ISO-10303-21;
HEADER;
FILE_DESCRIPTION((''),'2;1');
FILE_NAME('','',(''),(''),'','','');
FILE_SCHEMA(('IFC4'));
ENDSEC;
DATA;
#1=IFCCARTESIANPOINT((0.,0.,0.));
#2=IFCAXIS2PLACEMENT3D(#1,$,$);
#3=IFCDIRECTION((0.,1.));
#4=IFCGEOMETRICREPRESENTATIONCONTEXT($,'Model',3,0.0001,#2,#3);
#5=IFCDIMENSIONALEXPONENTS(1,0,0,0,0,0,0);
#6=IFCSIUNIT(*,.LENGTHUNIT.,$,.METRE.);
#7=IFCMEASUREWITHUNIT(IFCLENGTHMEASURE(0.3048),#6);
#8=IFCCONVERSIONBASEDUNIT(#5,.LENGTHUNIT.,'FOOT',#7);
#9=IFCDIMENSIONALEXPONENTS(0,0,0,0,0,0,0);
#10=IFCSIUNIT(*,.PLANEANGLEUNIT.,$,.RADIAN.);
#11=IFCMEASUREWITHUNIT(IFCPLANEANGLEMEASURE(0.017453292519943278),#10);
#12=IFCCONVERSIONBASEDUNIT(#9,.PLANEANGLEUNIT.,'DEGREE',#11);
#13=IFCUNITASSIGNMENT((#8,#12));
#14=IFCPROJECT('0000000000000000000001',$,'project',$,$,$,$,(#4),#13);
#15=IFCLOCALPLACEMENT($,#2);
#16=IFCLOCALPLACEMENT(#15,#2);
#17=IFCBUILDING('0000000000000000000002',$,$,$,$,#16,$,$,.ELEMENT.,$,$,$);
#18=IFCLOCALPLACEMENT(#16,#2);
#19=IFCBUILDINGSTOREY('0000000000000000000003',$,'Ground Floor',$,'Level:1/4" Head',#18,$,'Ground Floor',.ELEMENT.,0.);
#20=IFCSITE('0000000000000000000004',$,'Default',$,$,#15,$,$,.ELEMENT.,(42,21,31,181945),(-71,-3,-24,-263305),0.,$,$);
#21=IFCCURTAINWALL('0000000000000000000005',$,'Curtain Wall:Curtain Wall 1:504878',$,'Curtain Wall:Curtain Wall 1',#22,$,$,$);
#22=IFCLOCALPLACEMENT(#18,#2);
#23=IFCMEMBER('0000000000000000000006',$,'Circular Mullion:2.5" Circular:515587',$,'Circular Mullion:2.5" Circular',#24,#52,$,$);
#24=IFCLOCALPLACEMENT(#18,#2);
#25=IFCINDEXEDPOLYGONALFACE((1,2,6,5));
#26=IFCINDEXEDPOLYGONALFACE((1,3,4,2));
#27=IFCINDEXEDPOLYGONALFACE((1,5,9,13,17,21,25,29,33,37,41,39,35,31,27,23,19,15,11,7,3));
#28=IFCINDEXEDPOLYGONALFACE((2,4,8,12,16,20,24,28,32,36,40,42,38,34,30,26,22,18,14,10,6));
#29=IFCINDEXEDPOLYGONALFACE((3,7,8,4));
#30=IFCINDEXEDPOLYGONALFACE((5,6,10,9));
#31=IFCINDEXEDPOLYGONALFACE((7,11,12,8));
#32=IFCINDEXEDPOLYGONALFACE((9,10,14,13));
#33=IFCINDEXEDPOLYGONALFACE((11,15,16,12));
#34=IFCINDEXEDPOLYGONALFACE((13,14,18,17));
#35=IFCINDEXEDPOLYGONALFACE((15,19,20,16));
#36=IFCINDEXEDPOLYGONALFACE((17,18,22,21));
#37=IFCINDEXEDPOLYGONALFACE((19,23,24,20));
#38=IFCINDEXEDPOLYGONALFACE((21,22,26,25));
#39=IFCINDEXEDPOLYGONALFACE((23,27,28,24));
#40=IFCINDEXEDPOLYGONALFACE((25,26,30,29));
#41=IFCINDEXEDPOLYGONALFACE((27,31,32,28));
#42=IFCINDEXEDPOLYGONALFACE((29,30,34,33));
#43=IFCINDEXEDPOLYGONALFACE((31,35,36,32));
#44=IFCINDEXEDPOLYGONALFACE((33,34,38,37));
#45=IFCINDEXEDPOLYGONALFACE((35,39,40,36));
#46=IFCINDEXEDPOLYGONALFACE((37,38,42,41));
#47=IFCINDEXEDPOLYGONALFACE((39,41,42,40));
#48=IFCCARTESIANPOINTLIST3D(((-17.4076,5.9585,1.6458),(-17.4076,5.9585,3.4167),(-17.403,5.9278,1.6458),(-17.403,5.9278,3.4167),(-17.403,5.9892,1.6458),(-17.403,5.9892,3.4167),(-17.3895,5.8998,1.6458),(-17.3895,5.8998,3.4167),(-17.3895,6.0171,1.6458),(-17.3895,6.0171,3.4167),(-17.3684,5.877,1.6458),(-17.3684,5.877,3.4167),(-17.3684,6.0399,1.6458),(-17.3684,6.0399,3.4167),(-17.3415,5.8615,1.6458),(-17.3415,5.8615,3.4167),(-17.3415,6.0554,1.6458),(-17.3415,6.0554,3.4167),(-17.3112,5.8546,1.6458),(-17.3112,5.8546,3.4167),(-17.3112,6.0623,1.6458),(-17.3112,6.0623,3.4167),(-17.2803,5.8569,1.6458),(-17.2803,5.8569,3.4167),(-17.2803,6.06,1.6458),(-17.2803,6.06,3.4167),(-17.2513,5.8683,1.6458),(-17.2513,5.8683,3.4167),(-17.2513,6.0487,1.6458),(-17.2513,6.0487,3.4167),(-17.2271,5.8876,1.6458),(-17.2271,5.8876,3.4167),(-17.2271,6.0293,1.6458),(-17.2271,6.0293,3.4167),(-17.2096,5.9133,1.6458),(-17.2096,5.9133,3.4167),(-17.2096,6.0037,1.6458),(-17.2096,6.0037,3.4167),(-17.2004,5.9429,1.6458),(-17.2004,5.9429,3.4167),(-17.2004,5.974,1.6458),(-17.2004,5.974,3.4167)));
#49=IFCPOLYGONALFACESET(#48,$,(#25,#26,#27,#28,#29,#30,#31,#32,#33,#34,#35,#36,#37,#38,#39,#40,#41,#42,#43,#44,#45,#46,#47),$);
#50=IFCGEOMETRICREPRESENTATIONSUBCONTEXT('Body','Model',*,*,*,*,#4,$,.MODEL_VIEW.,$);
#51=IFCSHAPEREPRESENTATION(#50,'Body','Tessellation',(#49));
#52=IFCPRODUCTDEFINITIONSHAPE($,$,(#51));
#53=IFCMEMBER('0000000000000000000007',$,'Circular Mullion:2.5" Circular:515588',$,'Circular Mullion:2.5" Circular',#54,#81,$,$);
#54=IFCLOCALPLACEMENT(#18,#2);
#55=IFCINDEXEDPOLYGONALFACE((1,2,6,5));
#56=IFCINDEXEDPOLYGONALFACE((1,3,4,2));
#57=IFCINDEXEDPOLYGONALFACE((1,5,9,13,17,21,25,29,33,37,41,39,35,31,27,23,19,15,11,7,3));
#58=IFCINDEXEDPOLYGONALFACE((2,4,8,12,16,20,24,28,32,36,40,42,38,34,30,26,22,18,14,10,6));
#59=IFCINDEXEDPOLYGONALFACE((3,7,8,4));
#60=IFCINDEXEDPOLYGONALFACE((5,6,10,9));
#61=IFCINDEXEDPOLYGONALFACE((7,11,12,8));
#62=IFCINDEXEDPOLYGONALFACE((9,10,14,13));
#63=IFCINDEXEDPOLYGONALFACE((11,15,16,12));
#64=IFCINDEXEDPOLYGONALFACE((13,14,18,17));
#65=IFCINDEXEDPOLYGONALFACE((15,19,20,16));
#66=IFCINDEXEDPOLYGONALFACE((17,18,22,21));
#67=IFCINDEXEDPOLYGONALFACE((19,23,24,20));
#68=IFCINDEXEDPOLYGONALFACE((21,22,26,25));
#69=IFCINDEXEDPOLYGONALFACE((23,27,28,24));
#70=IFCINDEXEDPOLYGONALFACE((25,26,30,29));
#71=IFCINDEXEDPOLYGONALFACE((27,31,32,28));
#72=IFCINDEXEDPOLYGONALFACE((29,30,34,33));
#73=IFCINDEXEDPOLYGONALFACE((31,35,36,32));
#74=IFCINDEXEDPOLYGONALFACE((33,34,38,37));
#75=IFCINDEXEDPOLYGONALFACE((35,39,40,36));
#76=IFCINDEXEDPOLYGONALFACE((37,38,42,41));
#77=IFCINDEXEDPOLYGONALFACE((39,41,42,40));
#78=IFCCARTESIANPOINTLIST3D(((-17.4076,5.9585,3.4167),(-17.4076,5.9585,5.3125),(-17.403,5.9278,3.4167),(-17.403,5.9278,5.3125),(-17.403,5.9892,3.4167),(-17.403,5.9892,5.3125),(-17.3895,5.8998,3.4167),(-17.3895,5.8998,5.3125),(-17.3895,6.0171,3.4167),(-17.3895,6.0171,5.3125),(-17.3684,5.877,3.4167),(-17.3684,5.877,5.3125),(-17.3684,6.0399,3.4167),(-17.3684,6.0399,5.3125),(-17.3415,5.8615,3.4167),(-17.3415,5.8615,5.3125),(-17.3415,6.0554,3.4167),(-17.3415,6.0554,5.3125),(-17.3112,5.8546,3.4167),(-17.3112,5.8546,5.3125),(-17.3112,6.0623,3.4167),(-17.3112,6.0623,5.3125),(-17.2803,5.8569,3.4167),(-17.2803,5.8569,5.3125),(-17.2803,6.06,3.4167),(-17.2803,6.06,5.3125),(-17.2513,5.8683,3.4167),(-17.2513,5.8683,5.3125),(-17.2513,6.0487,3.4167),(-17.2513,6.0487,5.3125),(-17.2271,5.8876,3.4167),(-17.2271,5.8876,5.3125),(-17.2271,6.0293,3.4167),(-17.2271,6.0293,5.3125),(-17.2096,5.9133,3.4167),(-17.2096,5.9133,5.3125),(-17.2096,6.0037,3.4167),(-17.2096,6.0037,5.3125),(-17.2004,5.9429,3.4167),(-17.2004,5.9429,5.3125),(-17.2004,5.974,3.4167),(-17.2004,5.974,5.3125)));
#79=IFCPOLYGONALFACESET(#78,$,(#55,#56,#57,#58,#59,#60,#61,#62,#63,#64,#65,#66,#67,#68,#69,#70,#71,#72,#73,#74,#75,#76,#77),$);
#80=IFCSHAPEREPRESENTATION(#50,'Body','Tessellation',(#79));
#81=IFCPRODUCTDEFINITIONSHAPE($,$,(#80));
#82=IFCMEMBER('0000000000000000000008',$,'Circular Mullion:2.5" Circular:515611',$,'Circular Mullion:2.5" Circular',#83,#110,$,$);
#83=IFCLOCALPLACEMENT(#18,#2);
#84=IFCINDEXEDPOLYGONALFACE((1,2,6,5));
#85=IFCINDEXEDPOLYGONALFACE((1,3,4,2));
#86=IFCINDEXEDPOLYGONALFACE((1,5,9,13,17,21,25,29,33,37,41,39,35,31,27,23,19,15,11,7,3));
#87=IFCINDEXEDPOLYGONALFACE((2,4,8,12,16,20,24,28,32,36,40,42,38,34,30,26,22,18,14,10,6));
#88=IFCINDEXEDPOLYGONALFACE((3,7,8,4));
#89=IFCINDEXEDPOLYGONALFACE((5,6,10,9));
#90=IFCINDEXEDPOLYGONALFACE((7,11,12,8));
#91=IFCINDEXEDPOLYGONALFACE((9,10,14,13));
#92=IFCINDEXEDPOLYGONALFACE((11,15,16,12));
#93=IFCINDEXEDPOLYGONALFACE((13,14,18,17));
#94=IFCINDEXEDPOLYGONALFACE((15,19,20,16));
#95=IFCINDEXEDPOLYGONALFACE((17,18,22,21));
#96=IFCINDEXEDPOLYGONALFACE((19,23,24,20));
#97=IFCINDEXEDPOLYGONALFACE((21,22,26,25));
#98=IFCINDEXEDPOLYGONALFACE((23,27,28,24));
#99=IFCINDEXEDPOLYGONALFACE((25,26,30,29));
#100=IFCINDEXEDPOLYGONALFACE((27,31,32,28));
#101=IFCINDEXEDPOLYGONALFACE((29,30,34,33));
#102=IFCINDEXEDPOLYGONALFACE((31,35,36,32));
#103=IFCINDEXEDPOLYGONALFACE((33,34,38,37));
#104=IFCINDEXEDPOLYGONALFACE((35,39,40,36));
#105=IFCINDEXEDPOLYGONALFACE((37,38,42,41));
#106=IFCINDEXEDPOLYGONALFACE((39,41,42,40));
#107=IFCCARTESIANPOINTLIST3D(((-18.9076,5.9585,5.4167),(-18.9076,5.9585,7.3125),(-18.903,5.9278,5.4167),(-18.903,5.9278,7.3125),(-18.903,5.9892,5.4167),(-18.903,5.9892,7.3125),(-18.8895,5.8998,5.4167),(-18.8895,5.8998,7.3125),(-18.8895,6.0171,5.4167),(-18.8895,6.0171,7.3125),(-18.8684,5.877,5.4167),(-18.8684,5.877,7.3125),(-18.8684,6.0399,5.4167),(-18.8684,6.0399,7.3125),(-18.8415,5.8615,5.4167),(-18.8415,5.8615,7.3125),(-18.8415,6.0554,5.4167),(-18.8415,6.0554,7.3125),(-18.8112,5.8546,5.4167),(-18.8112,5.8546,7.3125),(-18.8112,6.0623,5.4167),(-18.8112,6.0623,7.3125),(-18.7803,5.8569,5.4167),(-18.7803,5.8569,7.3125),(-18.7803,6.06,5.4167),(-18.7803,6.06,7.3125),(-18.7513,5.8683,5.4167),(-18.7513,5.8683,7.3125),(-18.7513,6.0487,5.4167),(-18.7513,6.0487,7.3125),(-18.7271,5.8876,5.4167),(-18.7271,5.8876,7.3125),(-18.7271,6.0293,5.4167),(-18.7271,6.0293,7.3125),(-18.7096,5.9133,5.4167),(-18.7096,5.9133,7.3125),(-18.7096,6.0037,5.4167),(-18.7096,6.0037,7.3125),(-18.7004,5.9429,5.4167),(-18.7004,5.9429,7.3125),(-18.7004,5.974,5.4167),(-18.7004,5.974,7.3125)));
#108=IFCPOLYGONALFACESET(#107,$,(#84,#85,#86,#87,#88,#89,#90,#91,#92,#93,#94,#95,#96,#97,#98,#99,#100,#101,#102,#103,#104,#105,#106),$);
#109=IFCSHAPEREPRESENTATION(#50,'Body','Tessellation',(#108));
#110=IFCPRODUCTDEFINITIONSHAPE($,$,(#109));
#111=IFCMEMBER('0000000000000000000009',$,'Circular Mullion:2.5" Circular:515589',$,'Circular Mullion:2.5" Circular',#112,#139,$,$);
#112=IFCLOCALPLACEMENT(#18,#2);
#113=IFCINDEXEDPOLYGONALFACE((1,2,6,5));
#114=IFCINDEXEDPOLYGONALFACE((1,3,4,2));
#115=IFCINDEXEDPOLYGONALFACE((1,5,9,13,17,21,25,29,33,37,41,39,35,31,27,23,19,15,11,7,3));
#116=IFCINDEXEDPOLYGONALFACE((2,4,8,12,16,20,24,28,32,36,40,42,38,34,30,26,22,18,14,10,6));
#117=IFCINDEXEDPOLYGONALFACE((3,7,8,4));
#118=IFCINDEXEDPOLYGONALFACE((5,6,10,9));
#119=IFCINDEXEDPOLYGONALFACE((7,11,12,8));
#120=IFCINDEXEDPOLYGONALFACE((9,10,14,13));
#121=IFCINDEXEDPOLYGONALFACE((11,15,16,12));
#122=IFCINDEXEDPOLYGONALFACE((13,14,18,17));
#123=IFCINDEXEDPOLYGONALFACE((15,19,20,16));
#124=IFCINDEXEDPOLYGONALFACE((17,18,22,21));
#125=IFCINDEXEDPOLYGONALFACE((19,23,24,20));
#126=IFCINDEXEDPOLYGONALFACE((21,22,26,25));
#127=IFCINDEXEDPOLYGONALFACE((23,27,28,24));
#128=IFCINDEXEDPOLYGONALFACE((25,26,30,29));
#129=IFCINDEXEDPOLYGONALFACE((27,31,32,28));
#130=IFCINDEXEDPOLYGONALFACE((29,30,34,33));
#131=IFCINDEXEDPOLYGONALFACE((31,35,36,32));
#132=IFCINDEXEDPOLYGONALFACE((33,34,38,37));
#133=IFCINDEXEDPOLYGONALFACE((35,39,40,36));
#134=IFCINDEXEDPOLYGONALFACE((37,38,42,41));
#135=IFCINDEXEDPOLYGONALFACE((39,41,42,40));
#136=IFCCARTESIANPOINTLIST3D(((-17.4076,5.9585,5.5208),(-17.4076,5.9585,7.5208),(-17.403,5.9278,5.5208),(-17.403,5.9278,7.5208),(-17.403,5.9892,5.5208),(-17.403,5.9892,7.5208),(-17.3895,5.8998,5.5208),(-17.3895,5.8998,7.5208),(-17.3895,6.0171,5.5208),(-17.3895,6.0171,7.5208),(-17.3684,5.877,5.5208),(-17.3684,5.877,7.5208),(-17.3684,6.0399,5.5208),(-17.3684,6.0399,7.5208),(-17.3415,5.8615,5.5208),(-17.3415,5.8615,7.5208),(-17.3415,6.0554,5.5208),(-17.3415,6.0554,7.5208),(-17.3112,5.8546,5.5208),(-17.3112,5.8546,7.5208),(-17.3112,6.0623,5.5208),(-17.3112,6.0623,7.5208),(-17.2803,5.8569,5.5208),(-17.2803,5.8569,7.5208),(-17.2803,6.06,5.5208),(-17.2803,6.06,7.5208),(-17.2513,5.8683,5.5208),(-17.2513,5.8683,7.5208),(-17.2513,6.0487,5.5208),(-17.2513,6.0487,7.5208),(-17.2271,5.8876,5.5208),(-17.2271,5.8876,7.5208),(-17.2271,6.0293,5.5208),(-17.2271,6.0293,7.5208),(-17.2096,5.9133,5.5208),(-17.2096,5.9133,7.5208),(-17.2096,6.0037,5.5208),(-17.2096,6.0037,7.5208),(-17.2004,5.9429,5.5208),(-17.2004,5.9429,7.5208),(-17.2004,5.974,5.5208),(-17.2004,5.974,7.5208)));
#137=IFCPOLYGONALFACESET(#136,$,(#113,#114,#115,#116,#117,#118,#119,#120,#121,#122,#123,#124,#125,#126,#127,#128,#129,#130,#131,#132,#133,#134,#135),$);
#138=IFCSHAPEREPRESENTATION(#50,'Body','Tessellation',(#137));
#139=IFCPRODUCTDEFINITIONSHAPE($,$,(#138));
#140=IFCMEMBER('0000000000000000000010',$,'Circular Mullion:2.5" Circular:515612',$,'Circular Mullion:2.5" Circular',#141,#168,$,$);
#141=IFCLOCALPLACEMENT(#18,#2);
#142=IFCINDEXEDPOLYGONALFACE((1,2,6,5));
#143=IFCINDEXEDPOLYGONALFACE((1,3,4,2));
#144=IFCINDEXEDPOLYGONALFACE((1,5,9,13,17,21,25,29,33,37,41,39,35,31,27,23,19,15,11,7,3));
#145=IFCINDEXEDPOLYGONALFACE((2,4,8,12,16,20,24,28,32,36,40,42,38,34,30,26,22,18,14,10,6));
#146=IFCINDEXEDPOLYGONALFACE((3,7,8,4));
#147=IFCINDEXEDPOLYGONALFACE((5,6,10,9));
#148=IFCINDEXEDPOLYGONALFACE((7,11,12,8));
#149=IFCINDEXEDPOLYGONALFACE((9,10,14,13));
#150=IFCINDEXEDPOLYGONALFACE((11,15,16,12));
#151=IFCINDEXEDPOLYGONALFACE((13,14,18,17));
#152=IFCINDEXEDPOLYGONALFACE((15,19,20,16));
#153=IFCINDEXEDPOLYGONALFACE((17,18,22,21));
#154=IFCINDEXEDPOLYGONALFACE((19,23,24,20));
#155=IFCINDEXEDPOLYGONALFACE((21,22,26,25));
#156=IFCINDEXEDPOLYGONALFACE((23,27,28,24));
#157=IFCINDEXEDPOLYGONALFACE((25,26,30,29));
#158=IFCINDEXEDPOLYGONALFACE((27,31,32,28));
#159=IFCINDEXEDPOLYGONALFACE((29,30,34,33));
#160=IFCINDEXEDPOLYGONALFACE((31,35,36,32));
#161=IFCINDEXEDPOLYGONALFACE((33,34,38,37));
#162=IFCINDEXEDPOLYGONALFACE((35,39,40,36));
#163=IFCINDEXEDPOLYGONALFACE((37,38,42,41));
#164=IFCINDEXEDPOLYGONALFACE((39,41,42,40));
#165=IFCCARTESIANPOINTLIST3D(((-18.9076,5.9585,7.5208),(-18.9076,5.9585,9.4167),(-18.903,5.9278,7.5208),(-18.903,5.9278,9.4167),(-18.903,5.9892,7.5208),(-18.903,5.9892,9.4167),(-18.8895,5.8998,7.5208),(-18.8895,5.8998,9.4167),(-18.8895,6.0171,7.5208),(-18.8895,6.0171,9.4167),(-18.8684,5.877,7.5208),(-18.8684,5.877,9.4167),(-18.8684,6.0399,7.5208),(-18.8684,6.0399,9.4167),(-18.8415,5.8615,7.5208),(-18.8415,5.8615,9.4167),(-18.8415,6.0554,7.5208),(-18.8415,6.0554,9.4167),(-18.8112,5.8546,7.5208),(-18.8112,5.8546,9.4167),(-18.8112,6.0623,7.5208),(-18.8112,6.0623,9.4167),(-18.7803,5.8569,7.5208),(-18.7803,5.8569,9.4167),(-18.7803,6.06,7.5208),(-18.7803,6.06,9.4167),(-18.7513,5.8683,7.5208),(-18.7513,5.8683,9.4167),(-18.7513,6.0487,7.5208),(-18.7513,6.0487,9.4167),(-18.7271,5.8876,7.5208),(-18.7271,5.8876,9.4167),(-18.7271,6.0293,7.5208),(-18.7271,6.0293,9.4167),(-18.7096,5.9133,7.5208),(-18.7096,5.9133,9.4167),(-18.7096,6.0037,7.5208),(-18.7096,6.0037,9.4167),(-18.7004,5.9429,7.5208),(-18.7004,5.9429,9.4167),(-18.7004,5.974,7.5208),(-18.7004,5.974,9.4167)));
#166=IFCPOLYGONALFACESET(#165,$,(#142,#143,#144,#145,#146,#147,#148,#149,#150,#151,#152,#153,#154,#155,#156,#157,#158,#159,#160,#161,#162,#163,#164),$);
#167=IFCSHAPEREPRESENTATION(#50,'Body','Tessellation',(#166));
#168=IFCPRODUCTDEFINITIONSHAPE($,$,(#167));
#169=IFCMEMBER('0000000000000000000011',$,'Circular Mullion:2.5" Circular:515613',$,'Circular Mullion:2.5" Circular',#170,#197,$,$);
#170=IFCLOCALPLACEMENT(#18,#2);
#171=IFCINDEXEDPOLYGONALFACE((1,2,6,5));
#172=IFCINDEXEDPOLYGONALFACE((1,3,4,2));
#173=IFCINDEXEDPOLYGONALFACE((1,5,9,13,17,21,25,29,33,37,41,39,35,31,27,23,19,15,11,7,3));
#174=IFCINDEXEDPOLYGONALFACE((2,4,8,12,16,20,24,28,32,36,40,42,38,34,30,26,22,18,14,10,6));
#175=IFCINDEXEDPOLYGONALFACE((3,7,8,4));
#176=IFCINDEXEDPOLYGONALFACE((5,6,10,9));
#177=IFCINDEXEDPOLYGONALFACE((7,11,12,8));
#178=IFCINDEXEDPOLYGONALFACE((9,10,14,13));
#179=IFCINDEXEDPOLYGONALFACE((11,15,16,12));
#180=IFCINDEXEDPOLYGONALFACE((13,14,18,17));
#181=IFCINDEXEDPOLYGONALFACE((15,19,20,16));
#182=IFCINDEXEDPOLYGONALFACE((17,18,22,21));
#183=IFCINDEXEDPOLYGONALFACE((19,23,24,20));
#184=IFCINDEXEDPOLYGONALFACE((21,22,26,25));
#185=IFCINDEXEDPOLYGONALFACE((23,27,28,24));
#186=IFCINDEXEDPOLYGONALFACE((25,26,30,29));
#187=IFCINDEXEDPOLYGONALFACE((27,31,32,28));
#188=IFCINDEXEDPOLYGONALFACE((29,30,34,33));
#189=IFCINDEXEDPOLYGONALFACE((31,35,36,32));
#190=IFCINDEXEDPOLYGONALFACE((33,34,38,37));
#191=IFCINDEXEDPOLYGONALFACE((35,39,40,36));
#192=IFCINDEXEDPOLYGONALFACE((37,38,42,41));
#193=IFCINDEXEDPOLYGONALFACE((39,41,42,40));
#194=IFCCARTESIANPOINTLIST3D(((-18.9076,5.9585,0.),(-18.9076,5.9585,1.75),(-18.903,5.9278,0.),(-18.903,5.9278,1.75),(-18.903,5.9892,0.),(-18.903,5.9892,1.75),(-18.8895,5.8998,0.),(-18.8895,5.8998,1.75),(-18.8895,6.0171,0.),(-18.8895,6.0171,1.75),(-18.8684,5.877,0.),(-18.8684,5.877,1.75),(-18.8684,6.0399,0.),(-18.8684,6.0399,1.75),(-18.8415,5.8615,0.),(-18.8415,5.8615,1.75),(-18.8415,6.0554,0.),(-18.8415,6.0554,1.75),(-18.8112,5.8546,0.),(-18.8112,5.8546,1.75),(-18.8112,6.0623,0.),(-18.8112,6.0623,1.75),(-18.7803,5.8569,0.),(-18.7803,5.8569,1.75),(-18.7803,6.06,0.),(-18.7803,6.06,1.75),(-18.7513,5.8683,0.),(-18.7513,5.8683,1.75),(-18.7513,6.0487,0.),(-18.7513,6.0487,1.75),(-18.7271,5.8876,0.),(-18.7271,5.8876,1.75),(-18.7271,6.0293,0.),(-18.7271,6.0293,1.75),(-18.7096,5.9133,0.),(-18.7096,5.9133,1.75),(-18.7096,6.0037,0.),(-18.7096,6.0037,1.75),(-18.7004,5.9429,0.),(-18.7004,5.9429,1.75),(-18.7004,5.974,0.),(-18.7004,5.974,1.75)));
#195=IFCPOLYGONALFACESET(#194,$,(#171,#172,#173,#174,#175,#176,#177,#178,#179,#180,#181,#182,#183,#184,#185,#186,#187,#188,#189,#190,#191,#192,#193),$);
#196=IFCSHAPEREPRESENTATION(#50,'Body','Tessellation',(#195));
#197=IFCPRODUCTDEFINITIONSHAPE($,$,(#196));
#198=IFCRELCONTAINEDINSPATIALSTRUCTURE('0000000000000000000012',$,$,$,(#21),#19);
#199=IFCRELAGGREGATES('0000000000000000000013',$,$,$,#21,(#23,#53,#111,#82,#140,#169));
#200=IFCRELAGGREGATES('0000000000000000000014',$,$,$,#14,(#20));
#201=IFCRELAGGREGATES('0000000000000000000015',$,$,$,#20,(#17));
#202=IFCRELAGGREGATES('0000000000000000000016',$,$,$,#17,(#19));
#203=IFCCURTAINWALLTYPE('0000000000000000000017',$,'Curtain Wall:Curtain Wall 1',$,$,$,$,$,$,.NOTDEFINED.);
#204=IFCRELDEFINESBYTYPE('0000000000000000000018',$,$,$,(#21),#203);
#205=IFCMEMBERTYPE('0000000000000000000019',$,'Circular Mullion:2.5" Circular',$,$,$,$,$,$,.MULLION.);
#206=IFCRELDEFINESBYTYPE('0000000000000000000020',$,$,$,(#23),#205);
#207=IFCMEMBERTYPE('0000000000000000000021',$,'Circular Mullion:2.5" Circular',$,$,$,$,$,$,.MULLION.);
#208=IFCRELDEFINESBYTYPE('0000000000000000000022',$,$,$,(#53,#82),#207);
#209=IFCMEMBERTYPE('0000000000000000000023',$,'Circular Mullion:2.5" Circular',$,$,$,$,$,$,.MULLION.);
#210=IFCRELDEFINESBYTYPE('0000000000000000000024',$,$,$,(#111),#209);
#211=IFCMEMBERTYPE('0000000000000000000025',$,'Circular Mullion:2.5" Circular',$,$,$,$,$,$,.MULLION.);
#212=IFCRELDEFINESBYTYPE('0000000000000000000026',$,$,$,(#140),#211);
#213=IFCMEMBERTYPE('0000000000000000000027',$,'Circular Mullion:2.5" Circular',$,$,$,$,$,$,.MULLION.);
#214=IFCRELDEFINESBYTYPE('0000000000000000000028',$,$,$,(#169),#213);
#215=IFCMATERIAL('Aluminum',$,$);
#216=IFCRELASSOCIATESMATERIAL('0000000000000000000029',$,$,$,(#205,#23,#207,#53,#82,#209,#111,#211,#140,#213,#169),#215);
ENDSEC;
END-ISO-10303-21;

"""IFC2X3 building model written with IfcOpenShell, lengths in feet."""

from ifc_helpers import new_model, entity, si_unit, converted_unit, direction, frame, frame_2d, origin, place, context, subcontext, project, spatial, circle, extrude, source, transform, mapped, material, type_object, type_shapes, element, aggregate, save


model = new_model("IFC2X3")

# Units and contexts
model_context = context("Model", 3, precision=0.0001, world=origin(), true_north=direction((0.0, 1.0)))
body_context = subcontext(model_context, "Body", "Model", "MODEL_VIEW")
ifc_project = project(units=[converted_unit("LENGTHUNIT", "FOOT", entity("IfcLengthMeasure", 0.3048), si_unit("LENGTHUNIT", "METRE"), dimensions=[1, 0, 0, 0, 0, 0, 0]), converted_unit("PLANEANGLEUNIT", "DEGREE", entity("IfcPlaneAngleMeasure", 0.017453292519943278), si_unit("PLANEANGLEUNIT", "RADIAN"), dimensions=[0, 0, 0, 0, 0, 0, 0])], contexts=[model_context])

# Site, building, storey
site_placement = place(None, origin())
site = spatial("IfcSite", under=ifc_project, at=site_placement, Name="Default", CompositionType="ELEMENT", RefLatitude=(42, 21, 31, 181945), RefLongitude=(-71, -3, -24, -263305), RefElevation=0.0)
building_placement = place(site_placement, origin())
building = spatial("IfcBuilding", under=site, at=building_placement, CompositionType="ELEMENT")
storey_placement = place(building_placement, origin())
storey = spatial("IfcBuildingStorey", under=building, at=storey_placement, Name="Ground Floor", ObjectType="Level:1/4\" Head", LongName="Ground Floor", CompositionType="ELEMENT", Elevation=0.0)

# Curtain wall, members
curtain_wall_type = type_object("IfcCurtainWallType", Name="Curtain Wall:Curtain Wall 1", PredefinedType="NOTDEFINED")
curtain_wall_placement = place(storey_placement, origin())
curtain_wall = element("IfcCurtainWall", 1, at=curtain_wall_placement, inside=storey, type_object=curtain_wall_type, Name="Curtain Wall:Curtain Wall 1:504878", ObjectType="Curtain Wall:Curtain Wall 1")
ifc_material_1 = material(Name="Aluminum")
member_type_1 = type_object("IfcMemberType", Name="Circular Mullion:2.5\" Circular", PredefinedType="MULLION", material=ifc_material_1)
shared_shape_1 = source(origin(), body_context, "Body", "SweptSolid", [
    extrude(circle(Radius=0.1042, at=frame_2d((0.0, 0.0), x_axis=(1.0, 0.0))), frame((0.0, 0.0, -1.7708)), (0.0, 0.0, 1.0), 1.7708),
])
type_shapes(member_type_1, [shared_shape_1])
member_1_placement = place(curtain_wall_placement, frame((-17.3034, 5.9585, 1.6458), z_axis=(0.0, 0.0, -1.0), x_axis=(-1.0, 0.0, 0.0)))
member_1 = element("IfcMember", 2, at=member_1_placement, type_object=member_type_1, material=ifc_material_1, Name="Circular Mullion:2.5\" Circular:515587", ObjectType="Circular Mullion:2.5\" Circular", context=body_context, shape_type="MappedRepresentation", body=[
    mapped(shared_shape_1, transform((0.0, 0.0, 0.0), scale=1.0)),
])
member_type_2 = type_object("IfcMemberType", Name="Circular Mullion:2.5\" Circular", PredefinedType="MULLION", material=ifc_material_1)
shared_shape_2 = source(origin(), body_context, "Body", "SweptSolid", [
    extrude(circle(Radius=0.1042, at=frame_2d((0.0, 0.0), x_axis=(1.0, 0.0))), frame((0.0, 0.0, -1.8958)), (0.0, 0.0, 1.0), 1.8958),
])
type_shapes(member_type_2, [shared_shape_2])
member_2_placement = place(curtain_wall_placement, frame((-17.3034, 5.9585, 3.4167), z_axis=(0.0, 0.0, -1.0), x_axis=(-1.0, 0.0, 0.0)))
member_2 = element("IfcMember", 3, at=member_2_placement, type_object=member_type_2, material=ifc_material_1, Name="Circular Mullion:2.5\" Circular:515588", ObjectType="Circular Mullion:2.5\" Circular", context=body_context, shape_type="MappedRepresentation", body=[
    mapped(shared_shape_2, transform((0.0, 0.0, 0.0), scale=1.0)),
])
member_3_placement = place(curtain_wall_placement, frame((-18.8034, 5.9585, 5.4167), z_axis=(0.0, 0.0, -1.0), x_axis=(-1.0, 0.0, 0.0)))
member_3 = element("IfcMember", 4, at=member_3_placement, type_object=member_type_2, material=ifc_material_1, Name="Circular Mullion:2.5\" Circular:515611", ObjectType="Circular Mullion:2.5\" Circular", context=body_context, shape_type="MappedRepresentation", body=[
    mapped(shared_shape_2, transform((0.0, 0.0, 0.0), scale=1.0)),
])
member_type_3 = type_object("IfcMemberType", Name="Circular Mullion:2.5\" Circular", PredefinedType="MULLION", material=ifc_material_1)
shared_shape_3 = source(origin(), body_context, "Body", "SweptSolid", [
    extrude(circle(Radius=0.1042, at=frame_2d((0.0, 0.0), x_axis=(1.0, 0.0))), frame((0.0, 0.0, -2.0)), (0.0, 0.0, 1.0), 2.0),
])
type_shapes(member_type_3, [shared_shape_3])
member_4_placement = place(curtain_wall_placement, frame((-17.3034, 5.9585, 5.5208), z_axis=(0.0, 0.0, -1.0), x_axis=(-1.0, 0.0, 0.0)))
member_4 = element("IfcMember", 5, at=member_4_placement, type_object=member_type_3, material=ifc_material_1, Name="Circular Mullion:2.5\" Circular:515589", ObjectType="Circular Mullion:2.5\" Circular", context=body_context, shape_type="MappedRepresentation", body=[
    mapped(shared_shape_3, transform((0.0, 0.0, 0.0), scale=1.0)),
])
member_type_4 = type_object("IfcMemberType", Name="Circular Mullion:2.5\" Circular", PredefinedType="MULLION", material=ifc_material_1)
shared_shape_4 = source(origin(), body_context, "Body", "SweptSolid", [
    extrude(circle(Radius=0.1042, at=frame_2d((0.0, 0.0), x_axis=(1.0, 0.0))), frame((0.0, 0.0, -1.8958)), (0.0, 0.0, 1.0), 1.8958),
])
type_shapes(member_type_4, [shared_shape_4])
member_5_placement = place(curtain_wall_placement, frame((-18.8034, 5.9585, 7.5208), z_axis=(0.0, 0.0, -1.0), x_axis=(-1.0, 0.0, 0.0)))
member_5 = element("IfcMember", 6, at=member_5_placement, type_object=member_type_4, material=ifc_material_1, Name="Circular Mullion:2.5\" Circular:515612", ObjectType="Circular Mullion:2.5\" Circular", context=body_context, shape_type="MappedRepresentation", body=[
    mapped(shared_shape_4, transform((0.0, 0.0, 0.0), scale=1.0)),
])
member_type_5 = type_object("IfcMemberType", Name="Circular Mullion:2.5\" Circular", PredefinedType="MULLION", material=ifc_material_1)
shared_shape_5 = source(origin(), body_context, "Body", "SweptSolid", [
    extrude(circle(Radius=0.1042, at=frame_2d((0.0, 0.0), x_axis=(1.0, 0.0))), frame((0.0, 0.0, -1.75)), (0.0, 0.0, 1.0), 1.75),
])
type_shapes(member_type_5, [shared_shape_5])
member_6_placement = place(curtain_wall_placement, frame((-18.8034, 5.9585, 0.0), z_axis=(0.0, 0.0, -1.0), x_axis=(-1.0, 0.0, 0.0)))
member_6 = element("IfcMember", 7, at=member_6_placement, type_object=member_type_5, material=ifc_material_1, Name="Circular Mullion:2.5\" Circular:515613", ObjectType="Circular Mullion:2.5\" Circular", context=body_context, shape_type="MappedRepresentation", body=[
    mapped(shared_shape_5, transform((0.0, 0.0, 0.0), scale=1.0)),
])
aggregate(curtain_wall, [member_1, member_2, member_4, member_3, member_5, member_6])

save(model, "model.ifc")
